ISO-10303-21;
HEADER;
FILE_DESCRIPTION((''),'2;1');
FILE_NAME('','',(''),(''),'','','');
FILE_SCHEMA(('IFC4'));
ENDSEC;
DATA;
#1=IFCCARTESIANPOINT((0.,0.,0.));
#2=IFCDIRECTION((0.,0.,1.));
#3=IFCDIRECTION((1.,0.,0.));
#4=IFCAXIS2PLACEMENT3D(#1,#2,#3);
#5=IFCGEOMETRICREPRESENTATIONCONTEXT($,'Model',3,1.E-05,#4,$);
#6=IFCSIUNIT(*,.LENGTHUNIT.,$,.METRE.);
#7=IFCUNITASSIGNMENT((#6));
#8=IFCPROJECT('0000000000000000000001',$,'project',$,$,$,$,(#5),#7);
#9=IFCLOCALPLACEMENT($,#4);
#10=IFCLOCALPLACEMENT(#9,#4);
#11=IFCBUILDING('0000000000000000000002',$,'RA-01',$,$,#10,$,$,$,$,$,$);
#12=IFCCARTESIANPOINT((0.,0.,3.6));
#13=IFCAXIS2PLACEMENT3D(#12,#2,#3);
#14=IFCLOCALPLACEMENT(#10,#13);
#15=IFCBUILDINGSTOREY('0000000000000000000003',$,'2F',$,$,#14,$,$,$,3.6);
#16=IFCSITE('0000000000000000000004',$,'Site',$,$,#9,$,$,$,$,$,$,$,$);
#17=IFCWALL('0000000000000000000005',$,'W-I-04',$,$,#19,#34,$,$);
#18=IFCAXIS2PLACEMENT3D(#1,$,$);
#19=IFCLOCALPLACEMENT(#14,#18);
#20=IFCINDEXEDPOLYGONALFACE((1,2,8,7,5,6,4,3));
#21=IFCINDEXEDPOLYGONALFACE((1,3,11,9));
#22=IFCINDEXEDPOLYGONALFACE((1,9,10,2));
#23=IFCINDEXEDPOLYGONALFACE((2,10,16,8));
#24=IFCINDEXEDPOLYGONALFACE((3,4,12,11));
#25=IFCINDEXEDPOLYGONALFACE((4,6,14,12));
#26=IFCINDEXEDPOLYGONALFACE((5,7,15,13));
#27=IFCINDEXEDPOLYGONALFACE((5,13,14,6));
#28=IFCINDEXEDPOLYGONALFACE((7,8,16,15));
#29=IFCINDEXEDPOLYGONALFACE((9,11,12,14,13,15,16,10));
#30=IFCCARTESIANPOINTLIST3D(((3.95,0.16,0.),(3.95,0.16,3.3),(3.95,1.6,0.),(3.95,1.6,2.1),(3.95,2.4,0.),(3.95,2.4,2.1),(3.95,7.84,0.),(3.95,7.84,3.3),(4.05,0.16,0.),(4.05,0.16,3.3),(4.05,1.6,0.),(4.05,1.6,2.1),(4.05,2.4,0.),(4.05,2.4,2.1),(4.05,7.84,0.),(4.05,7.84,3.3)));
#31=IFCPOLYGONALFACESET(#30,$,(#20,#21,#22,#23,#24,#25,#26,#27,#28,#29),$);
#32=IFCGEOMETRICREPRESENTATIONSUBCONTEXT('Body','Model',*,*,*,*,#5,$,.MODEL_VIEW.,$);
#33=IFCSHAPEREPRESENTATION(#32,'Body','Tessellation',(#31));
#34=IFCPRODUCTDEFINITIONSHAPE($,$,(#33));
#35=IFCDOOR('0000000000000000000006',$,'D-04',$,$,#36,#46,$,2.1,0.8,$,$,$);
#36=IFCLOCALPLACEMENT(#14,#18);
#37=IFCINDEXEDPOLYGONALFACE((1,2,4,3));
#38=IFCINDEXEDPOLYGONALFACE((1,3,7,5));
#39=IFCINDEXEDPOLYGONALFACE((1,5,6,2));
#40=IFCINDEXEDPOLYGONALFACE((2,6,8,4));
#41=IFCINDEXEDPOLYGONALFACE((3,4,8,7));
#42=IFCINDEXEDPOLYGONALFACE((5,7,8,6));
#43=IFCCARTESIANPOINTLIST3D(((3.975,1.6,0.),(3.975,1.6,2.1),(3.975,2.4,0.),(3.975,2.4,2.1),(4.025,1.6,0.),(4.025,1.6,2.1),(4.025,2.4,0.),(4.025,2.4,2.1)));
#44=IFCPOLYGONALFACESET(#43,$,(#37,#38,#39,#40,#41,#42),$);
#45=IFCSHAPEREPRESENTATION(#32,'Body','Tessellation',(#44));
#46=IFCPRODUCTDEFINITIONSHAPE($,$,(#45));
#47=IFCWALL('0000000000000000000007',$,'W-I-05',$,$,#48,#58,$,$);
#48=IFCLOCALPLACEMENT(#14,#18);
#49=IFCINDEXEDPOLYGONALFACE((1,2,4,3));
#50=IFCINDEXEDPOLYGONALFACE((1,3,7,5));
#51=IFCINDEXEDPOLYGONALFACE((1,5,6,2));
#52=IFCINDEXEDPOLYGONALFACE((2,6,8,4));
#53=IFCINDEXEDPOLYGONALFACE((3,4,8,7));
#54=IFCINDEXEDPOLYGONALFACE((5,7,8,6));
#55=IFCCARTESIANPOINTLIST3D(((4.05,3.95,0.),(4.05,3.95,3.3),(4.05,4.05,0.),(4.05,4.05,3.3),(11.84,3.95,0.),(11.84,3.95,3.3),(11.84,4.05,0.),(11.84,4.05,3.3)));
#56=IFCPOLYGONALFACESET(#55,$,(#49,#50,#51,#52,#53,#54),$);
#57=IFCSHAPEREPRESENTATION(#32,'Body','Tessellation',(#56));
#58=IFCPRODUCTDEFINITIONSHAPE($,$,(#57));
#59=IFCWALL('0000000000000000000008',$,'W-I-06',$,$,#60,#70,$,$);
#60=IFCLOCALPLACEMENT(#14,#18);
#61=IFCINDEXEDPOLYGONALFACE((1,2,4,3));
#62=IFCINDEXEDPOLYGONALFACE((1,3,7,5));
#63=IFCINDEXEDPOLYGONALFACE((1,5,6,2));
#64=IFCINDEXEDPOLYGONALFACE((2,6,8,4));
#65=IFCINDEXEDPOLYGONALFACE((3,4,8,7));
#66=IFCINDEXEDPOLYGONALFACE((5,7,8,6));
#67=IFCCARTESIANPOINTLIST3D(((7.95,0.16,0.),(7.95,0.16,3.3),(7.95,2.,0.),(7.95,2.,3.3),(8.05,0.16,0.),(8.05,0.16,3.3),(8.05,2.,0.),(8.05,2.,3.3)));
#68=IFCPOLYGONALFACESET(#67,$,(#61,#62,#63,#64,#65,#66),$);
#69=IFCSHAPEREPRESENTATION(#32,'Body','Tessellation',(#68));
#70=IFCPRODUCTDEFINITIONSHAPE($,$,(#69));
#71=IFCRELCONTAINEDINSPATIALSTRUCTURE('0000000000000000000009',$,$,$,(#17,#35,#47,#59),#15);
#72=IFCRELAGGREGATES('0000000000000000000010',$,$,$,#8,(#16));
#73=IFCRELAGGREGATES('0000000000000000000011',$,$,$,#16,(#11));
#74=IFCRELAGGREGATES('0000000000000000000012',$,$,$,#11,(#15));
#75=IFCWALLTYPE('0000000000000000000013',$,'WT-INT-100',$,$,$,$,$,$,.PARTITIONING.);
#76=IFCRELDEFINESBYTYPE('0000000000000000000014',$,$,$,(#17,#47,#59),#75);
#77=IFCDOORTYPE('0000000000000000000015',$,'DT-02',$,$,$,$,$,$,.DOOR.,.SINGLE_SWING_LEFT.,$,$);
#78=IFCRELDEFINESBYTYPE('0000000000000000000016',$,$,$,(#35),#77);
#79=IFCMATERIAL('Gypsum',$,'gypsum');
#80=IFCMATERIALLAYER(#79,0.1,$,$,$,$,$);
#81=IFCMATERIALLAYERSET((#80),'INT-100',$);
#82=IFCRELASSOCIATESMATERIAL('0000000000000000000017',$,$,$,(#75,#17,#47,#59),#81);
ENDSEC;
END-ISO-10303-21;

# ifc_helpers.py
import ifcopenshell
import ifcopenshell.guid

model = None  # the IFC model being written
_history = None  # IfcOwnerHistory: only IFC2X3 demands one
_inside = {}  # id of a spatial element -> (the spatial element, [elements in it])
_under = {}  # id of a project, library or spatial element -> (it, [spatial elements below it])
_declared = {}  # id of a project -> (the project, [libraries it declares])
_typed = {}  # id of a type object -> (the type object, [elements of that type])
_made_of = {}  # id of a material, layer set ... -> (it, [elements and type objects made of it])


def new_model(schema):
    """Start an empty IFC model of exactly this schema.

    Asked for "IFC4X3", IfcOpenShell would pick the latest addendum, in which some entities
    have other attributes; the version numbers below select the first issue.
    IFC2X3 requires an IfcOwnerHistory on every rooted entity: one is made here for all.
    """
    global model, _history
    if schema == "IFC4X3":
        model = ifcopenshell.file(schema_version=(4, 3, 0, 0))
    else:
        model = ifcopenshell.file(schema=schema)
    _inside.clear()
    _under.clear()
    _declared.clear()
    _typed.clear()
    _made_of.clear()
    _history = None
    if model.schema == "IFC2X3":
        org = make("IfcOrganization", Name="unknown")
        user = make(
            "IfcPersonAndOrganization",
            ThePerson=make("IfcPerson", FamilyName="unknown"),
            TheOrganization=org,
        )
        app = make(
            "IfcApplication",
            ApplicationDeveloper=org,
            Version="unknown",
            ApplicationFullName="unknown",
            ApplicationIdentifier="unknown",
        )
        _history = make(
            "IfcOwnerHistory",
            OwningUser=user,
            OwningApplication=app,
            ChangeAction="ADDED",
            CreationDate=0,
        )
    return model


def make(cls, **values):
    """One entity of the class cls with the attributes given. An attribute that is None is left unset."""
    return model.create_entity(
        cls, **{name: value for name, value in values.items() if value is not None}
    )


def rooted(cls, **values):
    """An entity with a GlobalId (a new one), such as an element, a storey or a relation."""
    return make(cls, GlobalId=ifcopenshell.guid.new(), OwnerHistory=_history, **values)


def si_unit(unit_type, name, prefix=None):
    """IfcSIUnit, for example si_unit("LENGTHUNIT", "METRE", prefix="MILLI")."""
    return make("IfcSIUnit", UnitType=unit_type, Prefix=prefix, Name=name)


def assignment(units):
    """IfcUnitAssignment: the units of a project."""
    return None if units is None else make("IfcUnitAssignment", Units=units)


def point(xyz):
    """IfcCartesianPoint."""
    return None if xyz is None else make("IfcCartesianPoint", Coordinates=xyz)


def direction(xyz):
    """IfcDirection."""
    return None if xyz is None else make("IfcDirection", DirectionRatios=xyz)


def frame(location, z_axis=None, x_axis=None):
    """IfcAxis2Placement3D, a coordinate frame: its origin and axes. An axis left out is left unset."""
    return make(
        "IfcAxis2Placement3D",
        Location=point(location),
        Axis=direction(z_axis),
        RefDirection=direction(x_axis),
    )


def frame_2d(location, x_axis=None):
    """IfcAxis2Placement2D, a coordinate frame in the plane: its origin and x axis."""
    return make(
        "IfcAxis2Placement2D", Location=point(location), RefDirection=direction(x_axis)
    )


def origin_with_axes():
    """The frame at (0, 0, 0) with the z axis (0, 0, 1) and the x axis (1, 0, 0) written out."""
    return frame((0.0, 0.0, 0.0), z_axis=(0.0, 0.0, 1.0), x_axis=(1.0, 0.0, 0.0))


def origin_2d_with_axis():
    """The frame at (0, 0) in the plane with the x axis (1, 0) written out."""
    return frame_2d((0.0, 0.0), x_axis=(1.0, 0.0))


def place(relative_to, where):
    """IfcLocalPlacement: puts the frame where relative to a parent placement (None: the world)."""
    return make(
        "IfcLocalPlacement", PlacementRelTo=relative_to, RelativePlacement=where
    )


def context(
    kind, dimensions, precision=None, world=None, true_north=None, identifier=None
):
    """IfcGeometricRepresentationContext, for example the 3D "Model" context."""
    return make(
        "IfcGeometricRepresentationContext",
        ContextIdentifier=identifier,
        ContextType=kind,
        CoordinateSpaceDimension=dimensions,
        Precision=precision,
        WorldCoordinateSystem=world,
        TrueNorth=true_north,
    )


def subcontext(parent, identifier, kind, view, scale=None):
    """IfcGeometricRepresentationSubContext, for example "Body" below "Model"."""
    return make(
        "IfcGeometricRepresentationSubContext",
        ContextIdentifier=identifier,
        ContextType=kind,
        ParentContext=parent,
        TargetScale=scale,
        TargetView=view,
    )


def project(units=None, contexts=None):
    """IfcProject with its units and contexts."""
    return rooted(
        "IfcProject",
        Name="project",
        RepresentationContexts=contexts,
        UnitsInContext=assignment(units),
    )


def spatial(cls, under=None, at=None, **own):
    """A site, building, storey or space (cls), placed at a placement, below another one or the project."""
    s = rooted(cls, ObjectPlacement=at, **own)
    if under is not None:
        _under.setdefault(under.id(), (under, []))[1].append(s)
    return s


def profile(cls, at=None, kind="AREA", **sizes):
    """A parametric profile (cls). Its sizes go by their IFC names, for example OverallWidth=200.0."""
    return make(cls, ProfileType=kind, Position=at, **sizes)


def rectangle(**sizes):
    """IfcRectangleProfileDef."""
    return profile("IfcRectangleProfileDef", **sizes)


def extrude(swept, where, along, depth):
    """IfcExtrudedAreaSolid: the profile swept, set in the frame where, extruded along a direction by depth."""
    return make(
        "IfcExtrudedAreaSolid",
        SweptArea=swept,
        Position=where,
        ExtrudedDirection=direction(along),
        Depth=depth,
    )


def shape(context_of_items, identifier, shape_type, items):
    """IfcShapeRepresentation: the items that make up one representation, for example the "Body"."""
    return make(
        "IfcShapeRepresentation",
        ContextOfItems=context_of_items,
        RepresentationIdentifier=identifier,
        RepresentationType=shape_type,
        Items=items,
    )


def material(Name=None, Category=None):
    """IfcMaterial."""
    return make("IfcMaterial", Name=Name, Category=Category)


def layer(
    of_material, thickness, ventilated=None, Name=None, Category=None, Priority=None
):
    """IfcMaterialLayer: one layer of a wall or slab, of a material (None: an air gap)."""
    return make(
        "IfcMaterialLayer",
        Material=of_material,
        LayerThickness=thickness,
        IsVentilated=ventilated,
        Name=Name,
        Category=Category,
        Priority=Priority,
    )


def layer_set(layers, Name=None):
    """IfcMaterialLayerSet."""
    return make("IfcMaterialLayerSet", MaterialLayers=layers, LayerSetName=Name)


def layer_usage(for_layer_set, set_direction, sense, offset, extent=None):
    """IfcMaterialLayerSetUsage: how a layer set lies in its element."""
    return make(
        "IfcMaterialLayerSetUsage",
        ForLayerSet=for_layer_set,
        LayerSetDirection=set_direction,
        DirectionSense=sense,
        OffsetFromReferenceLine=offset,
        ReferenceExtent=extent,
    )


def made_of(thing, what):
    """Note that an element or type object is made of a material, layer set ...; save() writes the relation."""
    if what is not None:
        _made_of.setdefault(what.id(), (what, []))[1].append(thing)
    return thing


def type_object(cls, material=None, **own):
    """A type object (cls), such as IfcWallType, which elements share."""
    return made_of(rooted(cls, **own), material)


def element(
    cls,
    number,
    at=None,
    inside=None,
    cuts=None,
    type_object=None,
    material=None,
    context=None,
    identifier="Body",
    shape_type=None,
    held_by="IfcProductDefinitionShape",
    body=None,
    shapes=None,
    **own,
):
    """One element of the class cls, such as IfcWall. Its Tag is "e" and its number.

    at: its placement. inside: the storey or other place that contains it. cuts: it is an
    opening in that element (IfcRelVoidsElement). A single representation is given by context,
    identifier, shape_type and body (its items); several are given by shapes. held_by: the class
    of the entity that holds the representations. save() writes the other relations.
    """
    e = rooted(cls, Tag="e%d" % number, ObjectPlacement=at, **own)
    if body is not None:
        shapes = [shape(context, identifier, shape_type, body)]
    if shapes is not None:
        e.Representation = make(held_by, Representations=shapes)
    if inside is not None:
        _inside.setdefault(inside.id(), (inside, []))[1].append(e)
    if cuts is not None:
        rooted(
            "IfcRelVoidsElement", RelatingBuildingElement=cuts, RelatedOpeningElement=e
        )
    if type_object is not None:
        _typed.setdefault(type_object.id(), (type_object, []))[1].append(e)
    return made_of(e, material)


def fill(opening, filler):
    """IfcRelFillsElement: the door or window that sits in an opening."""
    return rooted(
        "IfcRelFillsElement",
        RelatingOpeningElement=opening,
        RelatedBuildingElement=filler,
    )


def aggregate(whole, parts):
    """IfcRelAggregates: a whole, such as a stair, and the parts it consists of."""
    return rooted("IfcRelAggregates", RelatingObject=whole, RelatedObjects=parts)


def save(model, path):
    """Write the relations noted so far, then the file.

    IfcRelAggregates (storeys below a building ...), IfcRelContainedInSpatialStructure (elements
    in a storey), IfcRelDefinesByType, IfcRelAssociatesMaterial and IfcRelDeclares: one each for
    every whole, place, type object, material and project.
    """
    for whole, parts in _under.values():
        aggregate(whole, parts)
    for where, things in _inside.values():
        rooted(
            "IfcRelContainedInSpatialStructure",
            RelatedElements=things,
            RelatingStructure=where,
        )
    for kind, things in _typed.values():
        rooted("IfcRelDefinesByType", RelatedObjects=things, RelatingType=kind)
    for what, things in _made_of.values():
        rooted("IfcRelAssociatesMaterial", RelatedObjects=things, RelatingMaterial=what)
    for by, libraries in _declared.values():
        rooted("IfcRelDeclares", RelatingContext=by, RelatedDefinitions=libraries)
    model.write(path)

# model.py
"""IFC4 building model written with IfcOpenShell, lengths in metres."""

from ifc_helpers import new_model, si_unit, frame, frame_2d, origin_with_axes, origin_2d_with_axis, place, context, subcontext, project, spatial, rectangle, extrude, material, layer, layer_set, layer_usage, type_object, element, fill, save


model = new_model("IFC4")

# Units and contexts
model_context = context("Model", 3, precision=1e-05, world=origin_with_axes())
body_context = subcontext(model_context, "Body", "Model", "MODEL_VIEW")
ifc_project = project(units=[si_unit("LENGTHUNIT", "METRE")], contexts=[model_context])

# Site, building, storey
site_placement = place(None, origin_with_axes())
site = spatial("IfcSite", under=ifc_project, at=site_placement, Name="Site")
building_placement = place(site_placement, origin_with_axes())
building = spatial("IfcBuilding", under=site, at=building_placement, Name="RA-01")
storey_placement = place(building_placement, frame((0.0, 0.0, 3.6), z_axis=(0.0, 0.0, 1.0), x_axis=(1.0, 0.0, 0.0)))
storey = spatial("IfcBuildingStorey", under=building, at=storey_placement, Name="2F", Elevation=3.6)

# Wall, opening, door
ifc_material_1 = material(Name="Gypsum", Category="gypsum")
ifc_layer_1 = layer(ifc_material_1, 0.1)
ifc_layer_set_1 = layer_set([ifc_layer_1], Name="INT-100")
ifc_layer_usage_1 = layer_usage(ifc_layer_set_1, "AXIS2", "POSITIVE", -0.05)
wall_type_1 = type_object("IfcWallType", Name="WT-INT-100", PredefinedType="PARTITIONING", material=ifc_layer_set_1)
wall_1_placement = place(storey_placement, frame((4.0, 0.16, 0.0), z_axis=(0.0, 0.0, 1.0), x_axis=(0.0, 1.0, 0.0)))
wall_1 = element("IfcWall", 1, at=wall_1_placement, inside=storey, type_object=wall_type_1, material=ifc_layer_usage_1, Name="W-I-04", context=body_context, shape_type="SweptSolid", body=[
    extrude(rectangle(XDim=7.68, YDim=0.1, at=frame_2d((3.84, 0.0), x_axis=(1.0, 0.0))), origin_with_axes(), (0.0, 0.0, 1.0), 3.3),
])
opening_1_placement = place(wall_1_placement, frame((1.84, 0.0, 0.0), z_axis=(0.0, 0.0, 1.0), x_axis=(1.0, 0.0, 0.0)))
opening_1 = element("IfcOpeningElement", 2, at=opening_1_placement, cuts=wall_1, PredefinedType="OPENING", context=body_context, shape_type="SweptSolid", body=[
    extrude(rectangle(XDim=0.8, YDim=0.2, at=origin_2d_with_axis()), origin_with_axes(), (0.0, 0.0, 1.0), 2.1),
])
door_type_1 = type_object("IfcDoorType", Name="DT-02", OperationType="SINGLE_SWING_LEFT", PredefinedType="DOOR")
door_1_placement = place(opening_1_placement, origin_with_axes())
door_1 = element("IfcDoor", 3, at=door_1_placement, inside=storey, type_object=door_type_1, Name="D-04", OverallHeight=2.1, OverallWidth=0.8, context=body_context, shape_type="SweptSolid", body=[
    extrude(rectangle(XDim=0.8, YDim=0.05, at=origin_2d_with_axis()), origin_with_axes(), (0.0, 0.0, 1.0), 2.1),
])
fill(opening_1, door_1)

# Walls
ifc_layer_usage_2 = layer_usage(ifc_layer_set_1, "AXIS2", "POSITIVE", -0.05)
wall_2_placement = place(storey_placement, frame((4.05, 4.0, 0.0), z_axis=(0.0, 0.0, 1.0), x_axis=(1.0, 0.0, 0.0)))
element("IfcWall", 4, at=wall_2_placement, inside=storey, type_object=wall_type_1, material=ifc_layer_usage_2, Name="W-I-05", context=body_context, shape_type="SweptSolid", body=[
    extrude(rectangle(XDim=7.79, YDim=0.1, at=frame_2d((3.895, 0.0), x_axis=(1.0, 0.0))), origin_with_axes(), (0.0, 0.0, 1.0), 3.3),
])
ifc_layer_usage_3 = layer_usage(ifc_layer_set_1, "AXIS2", "POSITIVE", -0.05)
wall_3_placement = place(storey_placement, frame((8.0, 0.16, 0.0), z_axis=(0.0, 0.0, 1.0), x_axis=(0.0, 1.0, 0.0)))
element("IfcWall", 5, at=wall_3_placement, inside=storey, type_object=wall_type_1, material=ifc_layer_usage_3, Name="W-I-06", context=body_context, shape_type="SweptSolid", body=[
    extrude(rectangle(XDim=1.84, YDim=0.1, at=frame_2d((0.92, 0.0), x_axis=(1.0, 0.0))), origin_with_axes(), (0.0, 0.0, 1.0), 3.3),
])

save(model, "model.ifc")
